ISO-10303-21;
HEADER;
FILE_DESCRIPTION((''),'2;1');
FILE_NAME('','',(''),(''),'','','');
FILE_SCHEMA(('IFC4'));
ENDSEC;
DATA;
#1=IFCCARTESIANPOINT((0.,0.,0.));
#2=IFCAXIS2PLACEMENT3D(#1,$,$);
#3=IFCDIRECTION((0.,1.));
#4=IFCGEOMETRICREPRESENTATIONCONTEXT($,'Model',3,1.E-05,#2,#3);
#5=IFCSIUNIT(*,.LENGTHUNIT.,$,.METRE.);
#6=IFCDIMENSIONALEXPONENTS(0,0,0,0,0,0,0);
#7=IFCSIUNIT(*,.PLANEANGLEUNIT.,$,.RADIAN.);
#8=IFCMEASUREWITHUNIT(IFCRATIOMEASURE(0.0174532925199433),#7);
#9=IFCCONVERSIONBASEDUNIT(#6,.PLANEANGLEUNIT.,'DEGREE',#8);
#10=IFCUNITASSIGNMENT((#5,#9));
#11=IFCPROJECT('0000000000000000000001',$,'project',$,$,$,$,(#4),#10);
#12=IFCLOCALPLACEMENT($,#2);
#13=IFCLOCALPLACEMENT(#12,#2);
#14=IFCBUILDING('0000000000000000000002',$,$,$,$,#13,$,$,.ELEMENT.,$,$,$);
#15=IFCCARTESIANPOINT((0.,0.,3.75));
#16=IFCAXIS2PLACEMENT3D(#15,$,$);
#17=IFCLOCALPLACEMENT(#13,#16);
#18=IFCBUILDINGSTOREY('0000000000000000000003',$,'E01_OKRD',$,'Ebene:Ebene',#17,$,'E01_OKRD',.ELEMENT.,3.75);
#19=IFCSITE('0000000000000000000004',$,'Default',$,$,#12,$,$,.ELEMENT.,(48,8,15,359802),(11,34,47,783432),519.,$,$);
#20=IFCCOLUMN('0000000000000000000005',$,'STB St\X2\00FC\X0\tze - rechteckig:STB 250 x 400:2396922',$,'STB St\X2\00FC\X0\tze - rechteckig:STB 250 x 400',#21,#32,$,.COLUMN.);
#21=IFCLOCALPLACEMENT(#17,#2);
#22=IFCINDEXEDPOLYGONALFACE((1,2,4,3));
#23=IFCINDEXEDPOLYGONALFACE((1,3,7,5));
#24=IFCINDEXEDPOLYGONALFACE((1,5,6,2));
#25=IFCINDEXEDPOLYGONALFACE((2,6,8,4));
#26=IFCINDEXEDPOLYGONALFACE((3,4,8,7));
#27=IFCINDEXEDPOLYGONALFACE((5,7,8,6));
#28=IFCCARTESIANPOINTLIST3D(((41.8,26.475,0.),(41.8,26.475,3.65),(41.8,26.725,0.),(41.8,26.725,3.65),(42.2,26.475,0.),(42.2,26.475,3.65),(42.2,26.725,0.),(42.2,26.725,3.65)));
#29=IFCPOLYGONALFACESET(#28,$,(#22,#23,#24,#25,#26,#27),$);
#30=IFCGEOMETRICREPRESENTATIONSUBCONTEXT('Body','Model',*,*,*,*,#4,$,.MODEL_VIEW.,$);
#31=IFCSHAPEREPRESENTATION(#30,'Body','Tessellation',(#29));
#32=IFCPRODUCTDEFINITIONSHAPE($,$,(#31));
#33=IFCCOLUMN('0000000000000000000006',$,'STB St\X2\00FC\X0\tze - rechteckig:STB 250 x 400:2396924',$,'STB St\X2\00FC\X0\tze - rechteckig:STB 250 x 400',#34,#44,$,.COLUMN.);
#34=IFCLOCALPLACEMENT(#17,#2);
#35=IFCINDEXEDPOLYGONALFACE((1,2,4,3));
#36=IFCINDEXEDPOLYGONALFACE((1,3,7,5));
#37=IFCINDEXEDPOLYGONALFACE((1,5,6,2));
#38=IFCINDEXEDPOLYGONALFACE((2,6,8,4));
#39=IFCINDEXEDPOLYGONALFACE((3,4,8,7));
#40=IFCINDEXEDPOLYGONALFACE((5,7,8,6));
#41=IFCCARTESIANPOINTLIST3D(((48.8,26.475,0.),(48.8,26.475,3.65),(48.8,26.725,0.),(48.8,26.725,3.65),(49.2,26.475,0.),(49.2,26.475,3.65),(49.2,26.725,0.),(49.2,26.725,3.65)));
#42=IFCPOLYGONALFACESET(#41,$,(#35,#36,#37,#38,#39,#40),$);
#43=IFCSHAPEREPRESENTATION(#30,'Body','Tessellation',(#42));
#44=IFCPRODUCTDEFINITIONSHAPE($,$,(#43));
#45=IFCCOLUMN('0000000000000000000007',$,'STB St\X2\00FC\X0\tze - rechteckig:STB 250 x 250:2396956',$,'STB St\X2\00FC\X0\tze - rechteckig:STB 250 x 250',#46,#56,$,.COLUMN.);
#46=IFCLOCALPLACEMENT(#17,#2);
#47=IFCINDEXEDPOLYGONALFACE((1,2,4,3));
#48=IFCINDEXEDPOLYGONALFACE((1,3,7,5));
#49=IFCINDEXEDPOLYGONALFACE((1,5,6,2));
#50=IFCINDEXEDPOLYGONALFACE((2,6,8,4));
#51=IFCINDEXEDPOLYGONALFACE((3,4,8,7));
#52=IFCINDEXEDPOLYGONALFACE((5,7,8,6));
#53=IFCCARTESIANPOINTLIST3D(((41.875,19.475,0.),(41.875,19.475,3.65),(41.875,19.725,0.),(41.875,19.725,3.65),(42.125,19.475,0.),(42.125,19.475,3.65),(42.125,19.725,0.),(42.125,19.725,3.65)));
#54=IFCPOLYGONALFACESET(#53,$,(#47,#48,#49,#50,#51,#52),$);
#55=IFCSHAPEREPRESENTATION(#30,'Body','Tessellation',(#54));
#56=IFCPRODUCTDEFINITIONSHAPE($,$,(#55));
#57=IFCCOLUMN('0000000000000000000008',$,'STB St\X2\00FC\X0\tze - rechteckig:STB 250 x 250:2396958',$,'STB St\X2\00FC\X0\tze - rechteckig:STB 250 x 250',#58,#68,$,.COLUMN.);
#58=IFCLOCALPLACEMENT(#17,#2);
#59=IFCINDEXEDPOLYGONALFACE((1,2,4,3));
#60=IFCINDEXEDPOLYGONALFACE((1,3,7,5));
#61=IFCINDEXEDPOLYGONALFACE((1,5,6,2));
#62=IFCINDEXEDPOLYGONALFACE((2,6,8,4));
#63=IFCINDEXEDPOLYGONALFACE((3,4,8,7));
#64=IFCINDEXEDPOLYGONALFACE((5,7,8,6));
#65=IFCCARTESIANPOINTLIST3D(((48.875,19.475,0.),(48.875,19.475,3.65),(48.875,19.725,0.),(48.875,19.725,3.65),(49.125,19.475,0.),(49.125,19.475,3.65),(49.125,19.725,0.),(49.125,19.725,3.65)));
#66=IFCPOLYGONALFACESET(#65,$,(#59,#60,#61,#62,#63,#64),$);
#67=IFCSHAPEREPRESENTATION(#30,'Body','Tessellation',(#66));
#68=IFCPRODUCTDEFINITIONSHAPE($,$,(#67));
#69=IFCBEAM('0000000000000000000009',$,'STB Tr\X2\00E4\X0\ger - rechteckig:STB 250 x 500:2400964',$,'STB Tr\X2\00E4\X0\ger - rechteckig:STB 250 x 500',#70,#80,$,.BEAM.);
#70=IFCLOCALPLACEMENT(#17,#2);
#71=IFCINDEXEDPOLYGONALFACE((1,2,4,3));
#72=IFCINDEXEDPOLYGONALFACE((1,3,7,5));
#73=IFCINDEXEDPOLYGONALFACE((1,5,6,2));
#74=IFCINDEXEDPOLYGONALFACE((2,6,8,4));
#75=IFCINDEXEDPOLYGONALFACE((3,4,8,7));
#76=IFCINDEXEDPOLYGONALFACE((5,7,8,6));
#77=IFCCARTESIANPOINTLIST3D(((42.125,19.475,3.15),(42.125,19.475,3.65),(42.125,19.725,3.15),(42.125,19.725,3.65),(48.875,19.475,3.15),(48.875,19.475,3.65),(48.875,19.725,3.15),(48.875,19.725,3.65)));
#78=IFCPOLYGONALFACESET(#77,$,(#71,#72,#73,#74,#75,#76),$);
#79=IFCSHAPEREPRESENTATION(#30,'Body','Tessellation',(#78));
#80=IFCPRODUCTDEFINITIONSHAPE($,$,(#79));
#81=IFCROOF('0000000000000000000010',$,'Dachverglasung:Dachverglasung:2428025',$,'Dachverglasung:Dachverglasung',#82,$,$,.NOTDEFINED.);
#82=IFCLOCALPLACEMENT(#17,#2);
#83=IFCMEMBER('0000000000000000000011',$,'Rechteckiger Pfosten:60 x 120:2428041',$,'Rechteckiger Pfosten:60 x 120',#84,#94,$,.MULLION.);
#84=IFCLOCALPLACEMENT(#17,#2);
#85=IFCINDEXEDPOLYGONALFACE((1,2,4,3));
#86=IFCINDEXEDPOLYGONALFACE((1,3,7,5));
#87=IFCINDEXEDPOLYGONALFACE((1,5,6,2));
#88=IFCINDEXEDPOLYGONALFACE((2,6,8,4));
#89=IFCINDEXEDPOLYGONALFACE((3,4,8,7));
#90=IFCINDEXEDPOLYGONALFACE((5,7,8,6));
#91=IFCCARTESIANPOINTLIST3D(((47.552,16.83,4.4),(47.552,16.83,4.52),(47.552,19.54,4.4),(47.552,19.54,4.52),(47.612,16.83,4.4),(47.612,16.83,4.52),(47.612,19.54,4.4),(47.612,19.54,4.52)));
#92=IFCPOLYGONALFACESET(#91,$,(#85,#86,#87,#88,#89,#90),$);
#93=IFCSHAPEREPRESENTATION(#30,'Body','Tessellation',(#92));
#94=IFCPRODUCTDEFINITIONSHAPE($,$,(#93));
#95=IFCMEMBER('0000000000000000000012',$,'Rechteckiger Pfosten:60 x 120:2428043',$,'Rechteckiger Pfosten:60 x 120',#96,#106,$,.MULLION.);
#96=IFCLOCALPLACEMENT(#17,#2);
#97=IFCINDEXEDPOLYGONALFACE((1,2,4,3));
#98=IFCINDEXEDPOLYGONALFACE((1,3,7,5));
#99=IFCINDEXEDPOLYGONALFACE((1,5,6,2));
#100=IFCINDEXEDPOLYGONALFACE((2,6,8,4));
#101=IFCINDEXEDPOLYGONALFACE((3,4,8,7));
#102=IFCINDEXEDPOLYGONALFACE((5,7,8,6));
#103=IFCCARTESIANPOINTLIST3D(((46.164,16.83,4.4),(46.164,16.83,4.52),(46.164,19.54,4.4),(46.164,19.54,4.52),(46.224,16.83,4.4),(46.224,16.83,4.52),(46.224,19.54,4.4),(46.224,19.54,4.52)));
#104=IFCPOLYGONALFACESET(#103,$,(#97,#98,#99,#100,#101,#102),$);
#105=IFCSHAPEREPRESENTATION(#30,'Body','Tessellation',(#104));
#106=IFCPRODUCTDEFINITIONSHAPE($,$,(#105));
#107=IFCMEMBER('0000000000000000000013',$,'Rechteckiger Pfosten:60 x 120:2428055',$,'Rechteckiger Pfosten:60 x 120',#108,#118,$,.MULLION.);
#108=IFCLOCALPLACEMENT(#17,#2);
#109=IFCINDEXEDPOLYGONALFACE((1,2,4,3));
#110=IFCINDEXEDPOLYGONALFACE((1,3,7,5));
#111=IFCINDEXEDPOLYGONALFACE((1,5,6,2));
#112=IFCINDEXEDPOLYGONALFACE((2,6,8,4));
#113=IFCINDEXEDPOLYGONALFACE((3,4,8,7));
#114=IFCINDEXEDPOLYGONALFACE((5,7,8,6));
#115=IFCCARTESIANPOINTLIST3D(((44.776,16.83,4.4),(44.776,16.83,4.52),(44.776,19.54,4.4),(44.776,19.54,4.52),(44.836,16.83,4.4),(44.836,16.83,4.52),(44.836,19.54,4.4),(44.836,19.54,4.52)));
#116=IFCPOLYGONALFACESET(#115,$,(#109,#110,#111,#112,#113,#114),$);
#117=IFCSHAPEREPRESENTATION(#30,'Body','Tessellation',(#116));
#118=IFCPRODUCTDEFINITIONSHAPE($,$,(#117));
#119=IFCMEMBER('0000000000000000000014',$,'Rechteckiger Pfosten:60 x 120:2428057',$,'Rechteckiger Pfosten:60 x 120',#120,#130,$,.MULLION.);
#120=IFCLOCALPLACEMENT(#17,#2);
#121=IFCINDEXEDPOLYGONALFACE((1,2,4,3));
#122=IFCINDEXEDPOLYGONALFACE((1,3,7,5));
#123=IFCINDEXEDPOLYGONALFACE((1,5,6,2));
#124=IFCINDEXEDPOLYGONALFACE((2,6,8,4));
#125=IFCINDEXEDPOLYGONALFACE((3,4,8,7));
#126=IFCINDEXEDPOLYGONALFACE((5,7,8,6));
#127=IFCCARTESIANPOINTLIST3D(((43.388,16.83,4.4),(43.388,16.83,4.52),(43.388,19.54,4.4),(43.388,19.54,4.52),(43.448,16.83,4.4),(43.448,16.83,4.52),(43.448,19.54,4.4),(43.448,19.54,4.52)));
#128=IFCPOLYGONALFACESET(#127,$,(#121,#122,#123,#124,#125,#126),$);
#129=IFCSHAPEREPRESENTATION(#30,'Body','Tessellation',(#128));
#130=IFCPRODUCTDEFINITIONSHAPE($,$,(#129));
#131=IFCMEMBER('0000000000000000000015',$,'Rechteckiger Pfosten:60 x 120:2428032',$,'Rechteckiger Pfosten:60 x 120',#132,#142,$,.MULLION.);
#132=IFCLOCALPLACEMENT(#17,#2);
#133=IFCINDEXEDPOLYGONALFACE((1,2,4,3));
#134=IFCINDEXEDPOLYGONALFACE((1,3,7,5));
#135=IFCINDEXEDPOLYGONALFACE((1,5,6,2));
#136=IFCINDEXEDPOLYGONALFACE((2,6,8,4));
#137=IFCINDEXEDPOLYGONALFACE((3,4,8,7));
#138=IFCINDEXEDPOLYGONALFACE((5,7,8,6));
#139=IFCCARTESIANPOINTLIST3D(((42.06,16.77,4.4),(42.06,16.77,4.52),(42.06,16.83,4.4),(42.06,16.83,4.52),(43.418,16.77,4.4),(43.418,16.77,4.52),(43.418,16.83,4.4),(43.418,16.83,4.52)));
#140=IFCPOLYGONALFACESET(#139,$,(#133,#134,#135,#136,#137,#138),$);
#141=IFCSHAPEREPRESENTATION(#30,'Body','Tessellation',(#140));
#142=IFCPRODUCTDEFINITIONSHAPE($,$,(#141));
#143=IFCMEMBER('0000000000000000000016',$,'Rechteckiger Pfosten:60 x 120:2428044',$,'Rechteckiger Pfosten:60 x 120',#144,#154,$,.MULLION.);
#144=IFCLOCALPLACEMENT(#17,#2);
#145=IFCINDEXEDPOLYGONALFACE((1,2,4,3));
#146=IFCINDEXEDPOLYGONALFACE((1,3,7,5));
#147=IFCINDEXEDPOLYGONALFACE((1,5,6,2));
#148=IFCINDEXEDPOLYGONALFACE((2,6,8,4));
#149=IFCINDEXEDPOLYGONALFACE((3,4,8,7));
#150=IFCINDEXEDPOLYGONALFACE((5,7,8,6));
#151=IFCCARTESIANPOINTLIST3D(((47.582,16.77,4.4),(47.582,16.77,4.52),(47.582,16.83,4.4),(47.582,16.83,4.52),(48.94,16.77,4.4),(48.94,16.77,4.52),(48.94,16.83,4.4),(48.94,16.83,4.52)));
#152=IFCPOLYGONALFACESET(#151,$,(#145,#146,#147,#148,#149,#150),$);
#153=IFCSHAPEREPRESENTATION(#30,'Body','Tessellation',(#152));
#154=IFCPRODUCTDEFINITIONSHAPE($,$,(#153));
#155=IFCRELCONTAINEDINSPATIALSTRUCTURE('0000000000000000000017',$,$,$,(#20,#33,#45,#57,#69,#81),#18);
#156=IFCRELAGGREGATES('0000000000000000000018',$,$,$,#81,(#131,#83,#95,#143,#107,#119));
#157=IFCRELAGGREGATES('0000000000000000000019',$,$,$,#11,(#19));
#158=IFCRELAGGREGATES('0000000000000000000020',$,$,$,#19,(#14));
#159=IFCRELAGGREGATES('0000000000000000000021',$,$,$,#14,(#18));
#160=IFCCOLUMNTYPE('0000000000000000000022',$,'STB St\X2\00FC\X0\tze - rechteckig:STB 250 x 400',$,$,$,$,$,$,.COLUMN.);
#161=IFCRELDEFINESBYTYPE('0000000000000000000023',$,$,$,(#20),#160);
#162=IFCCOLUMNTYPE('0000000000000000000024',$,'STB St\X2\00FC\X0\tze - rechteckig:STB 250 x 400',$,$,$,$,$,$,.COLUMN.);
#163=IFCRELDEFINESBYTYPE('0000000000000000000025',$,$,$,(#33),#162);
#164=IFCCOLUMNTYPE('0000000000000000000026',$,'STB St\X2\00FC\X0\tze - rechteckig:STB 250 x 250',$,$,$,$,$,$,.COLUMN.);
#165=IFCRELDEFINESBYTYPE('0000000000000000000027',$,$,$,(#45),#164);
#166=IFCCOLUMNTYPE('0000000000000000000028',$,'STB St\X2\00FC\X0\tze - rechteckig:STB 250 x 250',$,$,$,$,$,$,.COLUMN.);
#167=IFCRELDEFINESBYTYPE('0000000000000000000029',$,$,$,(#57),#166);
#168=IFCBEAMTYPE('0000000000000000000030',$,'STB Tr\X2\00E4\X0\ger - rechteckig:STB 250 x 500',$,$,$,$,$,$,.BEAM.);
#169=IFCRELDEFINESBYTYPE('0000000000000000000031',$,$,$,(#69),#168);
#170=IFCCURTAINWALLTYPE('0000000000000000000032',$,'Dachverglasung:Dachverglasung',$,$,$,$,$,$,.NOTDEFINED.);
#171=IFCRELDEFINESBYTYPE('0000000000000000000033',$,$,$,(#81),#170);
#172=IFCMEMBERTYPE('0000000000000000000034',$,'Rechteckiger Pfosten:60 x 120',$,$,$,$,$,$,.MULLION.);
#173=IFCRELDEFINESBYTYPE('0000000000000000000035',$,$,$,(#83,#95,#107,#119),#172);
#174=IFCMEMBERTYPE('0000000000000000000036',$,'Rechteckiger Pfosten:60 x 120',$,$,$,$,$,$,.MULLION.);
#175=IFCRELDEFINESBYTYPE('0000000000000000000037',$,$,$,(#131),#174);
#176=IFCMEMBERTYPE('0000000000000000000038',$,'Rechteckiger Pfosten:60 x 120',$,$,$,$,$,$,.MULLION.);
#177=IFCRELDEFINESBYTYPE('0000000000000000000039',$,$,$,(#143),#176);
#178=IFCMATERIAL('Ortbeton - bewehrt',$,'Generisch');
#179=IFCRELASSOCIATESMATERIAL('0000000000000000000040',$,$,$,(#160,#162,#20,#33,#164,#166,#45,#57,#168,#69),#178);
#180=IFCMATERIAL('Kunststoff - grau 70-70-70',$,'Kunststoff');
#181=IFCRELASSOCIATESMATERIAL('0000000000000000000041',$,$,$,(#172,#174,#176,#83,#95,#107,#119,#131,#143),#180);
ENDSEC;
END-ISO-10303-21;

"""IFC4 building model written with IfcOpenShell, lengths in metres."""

from ifc_helpers import new_model, entity, si_unit, converted_unit, direction, frame, frame_2d, origin, origin_2d_with_axis, place, context, subcontext, project, spatial, rectangle, extrude, source, transform, mapped, material, material_profile, profile_set, profile_usage, type_object, type_shapes, element, aggregate, save


model = new_model("IFC4")

# Units and contexts
model_context = context("Model", 3, precision=1e-05, world=origin(), true_north=direction((0.0, 1.0)))
body_context = subcontext(model_context, "Body", "Model", "MODEL_VIEW")
ifc_project = project(units=[si_unit("LENGTHUNIT", "METRE"), converted_unit("PLANEANGLEUNIT", "DEGREE", entity("IfcRatioMeasure", 0.0174532925199433), si_unit("PLANEANGLEUNIT", "RADIAN"), dimensions=[0, 0, 0, 0, 0, 0, 0])], contexts=[model_context])

# Site, building, storey
site_placement = place(None, frame((0.0, 0.0, 0.0)))
site = spatial("IfcSite", under=ifc_project, at=site_placement, Name="Default", CompositionType="ELEMENT", RefLatitude=(48, 8, 15, 359802), RefLongitude=(11, 34, 47, 783432), RefElevation=519.0)
building_placement = place(site_placement, origin())
building = spatial("IfcBuilding", under=site, at=building_placement, CompositionType="ELEMENT")
storey_placement = place(building_placement, frame((0.0, 0.0, 3.75)))
storey = spatial("IfcBuildingStorey", under=building, at=storey_placement, Name="E01_OKRD", ObjectType="Ebene:Ebene", LongName="E01_OKRD", CompositionType="ELEMENT", Elevation=3.75)

# Columns
ifc_material_1 = material(Name="Ortbeton - bewehrt", Category="Generisch")
ifc_material_profile_1 = material_profile(ifc_material_1, rectangle(XDim=0.4, YDim=0.25, at=frame_2d((0.0, 0.0), x_axis=(1.0, 0.0))), Name="STB 250 x 400")
ifc_profile_set_1 = profile_set([ifc_material_profile_1], Name="STB 250 x 400")
ifc_profile_usage_1 = profile_usage(ifc_profile_set_1)
column_type_1 = type_object("IfcColumnType", Name="STB Stütze - rechteckig:STB 250 x 400", PredefinedType="COLUMN", material=ifc_profile_set_1)
shared_shape_1 = source(origin(), body_context, "Body", "SweptSolid", [
    extrude(rectangle(XDim=0.4, YDim=0.25, at=origin_2d_with_axis()), frame((0.2, 0.125, 0.0), z_axis=(0.0, 0.0, 1.0), x_axis=(-1.0, 0.0, 0.0)), (0.0, 0.0, 1.0), 3.65),
])
type_shapes(column_type_1, [shared_shape_1])
column_1_placement = place(storey_placement, frame((41.8, 26.475, 0.0)))
element("IfcColumn", 1, at=column_1_placement, inside=storey, type_object=column_type_1, material=ifc_profile_usage_1, Name="STB Stütze - rechteckig:STB 250 x 400:2396922", ObjectType="STB Stütze - rechteckig:STB 250 x 400", PredefinedType="COLUMN", context=body_context, shape_type="MappedRepresentation", body=[
    mapped(shared_shape_1, transform((0.0, 0.0, 0.0), scale=1.0)),
])
ifc_profile_usage_2 = profile_usage(ifc_profile_set_1)
column_type_2 = type_object("IfcColumnType", Name="STB Stütze - rechteckig:STB 250 x 400", PredefinedType="COLUMN", material=ifc_profile_set_1)
shared_shape_2 = source(origin(), body_context, "Body", "SweptSolid", [
    extrude(rectangle(XDim=0.4, YDim=0.25, at=origin_2d_with_axis()), frame((0.2, 0.125, 0.0), z_axis=(0.0, 0.0, 1.0), x_axis=(-1.0, 0.0, 0.0)), (0.0, 0.0, 1.0), 3.65),
])
type_shapes(column_type_2, [shared_shape_2])
column_2_placement = place(storey_placement, frame((48.8, 26.475, 0.0)))
element("IfcColumn", 2, at=column_2_placement, inside=storey, type_object=column_type_2, material=ifc_profile_usage_2, Name="STB Stütze - rechteckig:STB 250 x 400:2396924", ObjectType="STB Stütze - rechteckig:STB 250 x 400", PredefinedType="COLUMN", context=body_context, shape_type="MappedRepresentation", body=[
    mapped(shared_shape_2, transform((0.0, 0.0, 0.0), scale=1.0)),
])
ifc_material_profile_2 = material_profile(ifc_material_1, rectangle(XDim=0.25, YDim=0.25, at=origin_2d_with_axis()), Name="STB 250 x 250")
ifc_profile_set_2 = profile_set([ifc_material_profile_2], Name="STB 250 x 250")
ifc_profile_usage_3 = profile_usage(ifc_profile_set_2)
column_type_3 = type_object("IfcColumnType", Name="STB Stütze - rechteckig:STB 250 x 250", PredefinedType="COLUMN", material=ifc_profile_set_2)
shared_shape_3 = source(origin(), body_context, "Body", "SweptSolid", [
    extrude(rectangle(XDim=0.25, YDim=0.25, at=frame_2d((0.0, 0.0), x_axis=(1.0, 0.0))), frame((0.125, 0.125, 0.0), z_axis=(0.0, 0.0, 1.0), x_axis=(-1.0, 0.0, 0.0)), (0.0, 0.0, 1.0), 3.65),
])
type_shapes(column_type_3, [shared_shape_3])
column_3_placement = place(storey_placement, frame((41.875, 19.475, 0.0)))
element("IfcColumn", 3, at=column_3_placement, inside=storey, type_object=column_type_3, material=ifc_profile_usage_3, Name="STB Stütze - rechteckig:STB 250 x 250:2396956", ObjectType="STB Stütze - rechteckig:STB 250 x 250", PredefinedType="COLUMN", context=body_context, shape_type="MappedRepresentation", body=[
    mapped(shared_shape_3, transform((0.0, 0.0, 0.0), scale=1.0)),
])
ifc_profile_usage_4 = profile_usage(ifc_profile_set_2)
column_type_4 = type_object("IfcColumnType", Name="STB Stütze - rechteckig:STB 250 x 250", PredefinedType="COLUMN", material=ifc_profile_set_2)
shared_shape_4 = source(origin(), body_context, "Body", "SweptSolid", [
    extrude(rectangle(XDim=0.25, YDim=0.25, at=frame_2d((0.0, 0.0), x_axis=(1.0, 0.0))), frame((0.125, 0.125, 0.0), z_axis=(0.0, 0.0, 1.0), x_axis=(-1.0, 0.0, 0.0)), (0.0, 0.0, 1.0), 3.65),
])
type_shapes(column_type_4, [shared_shape_4])
column_4_placement = place(storey_placement, frame((48.875, 19.475, 0.0)))
element("IfcColumn", 4, at=column_4_placement, inside=storey, type_object=column_type_4, material=ifc_profile_usage_4, Name="STB Stütze - rechteckig:STB 250 x 250:2396958", ObjectType="STB Stütze - rechteckig:STB 250 x 250", PredefinedType="COLUMN", context=body_context, shape_type="MappedRepresentation", body=[
    mapped(shared_shape_4, transform((0.0, 0.0, 0.0), scale=1.0)),
])

# Beam
ifc_material_profile_3 = material_profile(ifc_material_1, rectangle(XDim=0.5, YDim=0.25, at=frame_2d((0.0, 0.0), x_axis=(1.0, 0.0))), Name="STB 250 x 500")
ifc_profile_set_3 = profile_set([ifc_material_profile_3], Name="STB 250 x 500")
ifc_profile_usage_5 = profile_usage(ifc_profile_set_3, cardinal=8)
beam_type = type_object("IfcBeamType", Name="STB Träger - rechteckig:STB 250 x 500", PredefinedType="BEAM", material=ifc_profile_set_3)
shared_shape_5 = source(origin(), body_context, "Body", "SweptSolid", [
    extrude(rectangle(XDim=0.5, YDim=0.25, at=frame_2d((0.0, 0.0), x_axis=(1.0, 0.0))), frame((0.0, 0.125, 0.25), z_axis=(1.0, 0.0, 0.0), x_axis=(0.0, 0.0, -1.0)), (0.0, 0.0, 1.0), 6.75),
])
type_shapes(beam_type, [shared_shape_5])
beam_placement = place(storey_placement, frame((42.125, 19.475, 3.15)))
element("IfcBeam", 5, at=beam_placement, inside=storey, type_object=beam_type, material=ifc_profile_usage_5, Name="STB Träger - rechteckig:STB 250 x 500:2400964", ObjectType="STB Träger - rechteckig:STB 250 x 500", PredefinedType="BEAM", context=body_context, shape_type="MappedRepresentation", body=[
    mapped(shared_shape_5, transform((0.0, 0.0, 0.0), scale=1.0)),
])

# Roof, members
curtain_wall_type = type_object("IfcCurtainWallType", Name="Dachverglasung:Dachverglasung", PredefinedType="NOTDEFINED")
roof_placement = place(storey_placement, frame((0.0, 0.0, -3.75)))
roof = element("IfcRoof", 6, at=roof_placement, inside=storey, type_object=curtain_wall_type, Name="Dachverglasung:Dachverglasung:2428025", ObjectType="Dachverglasung:Dachverglasung", PredefinedType="NOTDEFINED")
ifc_material_2 = material(Name="Kunststoff - grau 70-70-70", Category="Kunststoff")
ifc_material_profile_4 = material_profile(ifc_material_2, rectangle(XDim=0.06, YDim=0.12, at=frame_2d((0.0, 0.0), x_axis=(1.0, 0.0))), Name="60 x 120")
ifc_profile_set_4 = profile_set([ifc_material_profile_4], Name="60 x 120")
ifc_profile_usage_6 = profile_usage(ifc_profile_set_4)
member_type_1 = type_object("IfcMemberType", Name="Rechteckiger Pfosten:60 x 120", PredefinedType="MULLION", material=ifc_profile_set_4)
shared_shape_6 = source(origin(), body_context, "Body", "SweptSolid", [
    extrude(rectangle(XDim=0.06, YDim=0.12, at=frame_2d((0.0, 0.0), x_axis=(1.0, 0.0))), frame((0.0, 0.0, -2.71), z_axis=(0.0, 0.0, 1.0), x_axis=(-1.0, 0.0, 0.0)), (0.0, 0.0, 1.0), 2.71),
])
type_shapes(member_type_1, [shared_shape_6])
member_1_placement = place(storey_placement, frame((47.582, 16.83, 4.46), z_axis=(0.0, -1.0, 0.0), x_axis=(-1.0, 0.0, 0.0)))
member_1 = element("IfcMember", 7, at=member_1_placement, type_object=member_type_1, material=ifc_profile_usage_6, Name="Rechteckiger Pfosten:60 x 120:2428041", ObjectType="Rechteckiger Pfosten:60 x 120", PredefinedType="MULLION", context=body_context, shape_type="MappedRepresentation", body=[
    mapped(shared_shape_6, transform((0.0, 0.0, 0.0), scale=1.0)),
])
ifc_profile_usage_7 = profile_usage(ifc_profile_set_4)
member_2_placement = place(storey_placement, frame((46.194, 16.83, 4.46), z_axis=(0.0, -1.0, 0.0), x_axis=(-1.0, 0.0, 0.0)))
member_2 = element("IfcMember", 8, at=member_2_placement, type_object=member_type_1, material=ifc_profile_usage_7, Name="Rechteckiger Pfosten:60 x 120:2428043", ObjectType="Rechteckiger Pfosten:60 x 120", PredefinedType="MULLION", context=body_context, shape_type="MappedRepresentation", body=[
    mapped(shared_shape_6, transform((0.0, 0.0, 0.0), scale=1.0)),
])
ifc_profile_usage_8 = profile_usage(ifc_profile_set_4)
member_3_placement = place(storey_placement, frame((44.806, 16.83, 4.46), z_axis=(0.0, -1.0, 0.0), x_axis=(-1.0, 0.0, 0.0)))
member_3 = element("IfcMember", 9, at=member_3_placement, type_object=member_type_1, material=ifc_profile_usage_8, Name="Rechteckiger Pfosten:60 x 120:2428055", ObjectType="Rechteckiger Pfosten:60 x 120", PredefinedType="MULLION", context=body_context, shape_type="MappedRepresentation", body=[
    mapped(shared_shape_6, transform((0.0, 0.0, 0.0), scale=1.0)),
])
ifc_profile_usage_9 = profile_usage(ifc_profile_set_4)
member_4_placement = place(storey_placement, frame((43.418, 16.83, 4.46), z_axis=(0.0, -1.0, 0.0), x_axis=(-1.0, 0.0, 0.0)))
member_4 = element("IfcMember", 10, at=member_4_placement, type_object=member_type_1, material=ifc_profile_usage_9, Name="Rechteckiger Pfosten:60 x 120:2428057", ObjectType="Rechteckiger Pfosten:60 x 120", PredefinedType="MULLION", context=body_context, shape_type="MappedRepresentation", body=[
    mapped(shared_shape_6, transform((0.0, 0.0, 0.0), scale=1.0)),
])
ifc_profile_usage_10 = profile_usage(ifc_profile_set_4)
member_type_2 = type_object("IfcMemberType", Name="Rechteckiger Pfosten:60 x 120", PredefinedType="MULLION", material=ifc_profile_set_4)
shared_shape_7 = source(origin(), body_context, "Body", "SweptSolid", [
    extrude(rectangle(XDim=0.06, YDim=0.12, at=frame_2d((0.0, 0.0), x_axis=(1.0, 0.0))), frame((0.0, 0.0, -1.358), z_axis=(0.0, 0.0, 1.0), x_axis=(-1.0, 0.0, 0.0)), (0.0, 0.0, 1.0), 1.358),
])
type_shapes(member_type_2, [shared_shape_7])
member_5_placement = place(storey_placement, frame((42.06, 16.8, 4.46), z_axis=(-1.0, 0.0, 0.0), x_axis=(0.0, 1.0, 0.0)))
member_5 = element("IfcMember", 11, at=member_5_placement, type_object=member_type_2, material=ifc_profile_usage_10, Name="Rechteckiger Pfosten:60 x 120:2428032", ObjectType="Rechteckiger Pfosten:60 x 120", PredefinedType="MULLION", context=body_context, shape_type="MappedRepresentation", body=[
    mapped(shared_shape_7, transform((0.0, 0.0, 0.0), scale=1.0)),
])
ifc_profile_usage_11 = profile_usage(ifc_profile_set_4)
member_type_3 = type_object("IfcMemberType", Name="Rechteckiger Pfosten:60 x 120", PredefinedType="MULLION", material=ifc_profile_set_4)
shared_shape_8 = source(origin(), body_context, "Body", "SweptSolid", [
    extrude(rectangle(XDim=0.06, YDim=0.12, at=frame_2d((0.0, 0.0), x_axis=(1.0, 0.0))), frame((0.0, 0.0, -1.358), z_axis=(0.0, 0.0, 1.0), x_axis=(-1.0, 0.0, 0.0)), (0.0, 0.0, 1.0), 1.358),
])
type_shapes(member_type_3, [shared_shape_8])
member_6_placement = place(storey_placement, frame((47.582, 16.8, 4.46), z_axis=(-1.0, 0.0, 0.0), x_axis=(0.0, 1.0, 0.0)))
member_6 = element("IfcMember", 12, at=member_6_placement, type_object=member_type_3, material=ifc_profile_usage_11, Name="Rechteckiger Pfosten:60 x 120:2428044", ObjectType="Rechteckiger Pfosten:60 x 120", PredefinedType="MULLION", context=body_context, shape_type="MappedRepresentation", body=[
    mapped(shared_shape_8, transform((0.0, 0.0, 0.0), scale=1.0)),
])
aggregate(roof, [member_5, member_1, member_2, member_6, member_3, member_4])

save(model, "model.ifc")
